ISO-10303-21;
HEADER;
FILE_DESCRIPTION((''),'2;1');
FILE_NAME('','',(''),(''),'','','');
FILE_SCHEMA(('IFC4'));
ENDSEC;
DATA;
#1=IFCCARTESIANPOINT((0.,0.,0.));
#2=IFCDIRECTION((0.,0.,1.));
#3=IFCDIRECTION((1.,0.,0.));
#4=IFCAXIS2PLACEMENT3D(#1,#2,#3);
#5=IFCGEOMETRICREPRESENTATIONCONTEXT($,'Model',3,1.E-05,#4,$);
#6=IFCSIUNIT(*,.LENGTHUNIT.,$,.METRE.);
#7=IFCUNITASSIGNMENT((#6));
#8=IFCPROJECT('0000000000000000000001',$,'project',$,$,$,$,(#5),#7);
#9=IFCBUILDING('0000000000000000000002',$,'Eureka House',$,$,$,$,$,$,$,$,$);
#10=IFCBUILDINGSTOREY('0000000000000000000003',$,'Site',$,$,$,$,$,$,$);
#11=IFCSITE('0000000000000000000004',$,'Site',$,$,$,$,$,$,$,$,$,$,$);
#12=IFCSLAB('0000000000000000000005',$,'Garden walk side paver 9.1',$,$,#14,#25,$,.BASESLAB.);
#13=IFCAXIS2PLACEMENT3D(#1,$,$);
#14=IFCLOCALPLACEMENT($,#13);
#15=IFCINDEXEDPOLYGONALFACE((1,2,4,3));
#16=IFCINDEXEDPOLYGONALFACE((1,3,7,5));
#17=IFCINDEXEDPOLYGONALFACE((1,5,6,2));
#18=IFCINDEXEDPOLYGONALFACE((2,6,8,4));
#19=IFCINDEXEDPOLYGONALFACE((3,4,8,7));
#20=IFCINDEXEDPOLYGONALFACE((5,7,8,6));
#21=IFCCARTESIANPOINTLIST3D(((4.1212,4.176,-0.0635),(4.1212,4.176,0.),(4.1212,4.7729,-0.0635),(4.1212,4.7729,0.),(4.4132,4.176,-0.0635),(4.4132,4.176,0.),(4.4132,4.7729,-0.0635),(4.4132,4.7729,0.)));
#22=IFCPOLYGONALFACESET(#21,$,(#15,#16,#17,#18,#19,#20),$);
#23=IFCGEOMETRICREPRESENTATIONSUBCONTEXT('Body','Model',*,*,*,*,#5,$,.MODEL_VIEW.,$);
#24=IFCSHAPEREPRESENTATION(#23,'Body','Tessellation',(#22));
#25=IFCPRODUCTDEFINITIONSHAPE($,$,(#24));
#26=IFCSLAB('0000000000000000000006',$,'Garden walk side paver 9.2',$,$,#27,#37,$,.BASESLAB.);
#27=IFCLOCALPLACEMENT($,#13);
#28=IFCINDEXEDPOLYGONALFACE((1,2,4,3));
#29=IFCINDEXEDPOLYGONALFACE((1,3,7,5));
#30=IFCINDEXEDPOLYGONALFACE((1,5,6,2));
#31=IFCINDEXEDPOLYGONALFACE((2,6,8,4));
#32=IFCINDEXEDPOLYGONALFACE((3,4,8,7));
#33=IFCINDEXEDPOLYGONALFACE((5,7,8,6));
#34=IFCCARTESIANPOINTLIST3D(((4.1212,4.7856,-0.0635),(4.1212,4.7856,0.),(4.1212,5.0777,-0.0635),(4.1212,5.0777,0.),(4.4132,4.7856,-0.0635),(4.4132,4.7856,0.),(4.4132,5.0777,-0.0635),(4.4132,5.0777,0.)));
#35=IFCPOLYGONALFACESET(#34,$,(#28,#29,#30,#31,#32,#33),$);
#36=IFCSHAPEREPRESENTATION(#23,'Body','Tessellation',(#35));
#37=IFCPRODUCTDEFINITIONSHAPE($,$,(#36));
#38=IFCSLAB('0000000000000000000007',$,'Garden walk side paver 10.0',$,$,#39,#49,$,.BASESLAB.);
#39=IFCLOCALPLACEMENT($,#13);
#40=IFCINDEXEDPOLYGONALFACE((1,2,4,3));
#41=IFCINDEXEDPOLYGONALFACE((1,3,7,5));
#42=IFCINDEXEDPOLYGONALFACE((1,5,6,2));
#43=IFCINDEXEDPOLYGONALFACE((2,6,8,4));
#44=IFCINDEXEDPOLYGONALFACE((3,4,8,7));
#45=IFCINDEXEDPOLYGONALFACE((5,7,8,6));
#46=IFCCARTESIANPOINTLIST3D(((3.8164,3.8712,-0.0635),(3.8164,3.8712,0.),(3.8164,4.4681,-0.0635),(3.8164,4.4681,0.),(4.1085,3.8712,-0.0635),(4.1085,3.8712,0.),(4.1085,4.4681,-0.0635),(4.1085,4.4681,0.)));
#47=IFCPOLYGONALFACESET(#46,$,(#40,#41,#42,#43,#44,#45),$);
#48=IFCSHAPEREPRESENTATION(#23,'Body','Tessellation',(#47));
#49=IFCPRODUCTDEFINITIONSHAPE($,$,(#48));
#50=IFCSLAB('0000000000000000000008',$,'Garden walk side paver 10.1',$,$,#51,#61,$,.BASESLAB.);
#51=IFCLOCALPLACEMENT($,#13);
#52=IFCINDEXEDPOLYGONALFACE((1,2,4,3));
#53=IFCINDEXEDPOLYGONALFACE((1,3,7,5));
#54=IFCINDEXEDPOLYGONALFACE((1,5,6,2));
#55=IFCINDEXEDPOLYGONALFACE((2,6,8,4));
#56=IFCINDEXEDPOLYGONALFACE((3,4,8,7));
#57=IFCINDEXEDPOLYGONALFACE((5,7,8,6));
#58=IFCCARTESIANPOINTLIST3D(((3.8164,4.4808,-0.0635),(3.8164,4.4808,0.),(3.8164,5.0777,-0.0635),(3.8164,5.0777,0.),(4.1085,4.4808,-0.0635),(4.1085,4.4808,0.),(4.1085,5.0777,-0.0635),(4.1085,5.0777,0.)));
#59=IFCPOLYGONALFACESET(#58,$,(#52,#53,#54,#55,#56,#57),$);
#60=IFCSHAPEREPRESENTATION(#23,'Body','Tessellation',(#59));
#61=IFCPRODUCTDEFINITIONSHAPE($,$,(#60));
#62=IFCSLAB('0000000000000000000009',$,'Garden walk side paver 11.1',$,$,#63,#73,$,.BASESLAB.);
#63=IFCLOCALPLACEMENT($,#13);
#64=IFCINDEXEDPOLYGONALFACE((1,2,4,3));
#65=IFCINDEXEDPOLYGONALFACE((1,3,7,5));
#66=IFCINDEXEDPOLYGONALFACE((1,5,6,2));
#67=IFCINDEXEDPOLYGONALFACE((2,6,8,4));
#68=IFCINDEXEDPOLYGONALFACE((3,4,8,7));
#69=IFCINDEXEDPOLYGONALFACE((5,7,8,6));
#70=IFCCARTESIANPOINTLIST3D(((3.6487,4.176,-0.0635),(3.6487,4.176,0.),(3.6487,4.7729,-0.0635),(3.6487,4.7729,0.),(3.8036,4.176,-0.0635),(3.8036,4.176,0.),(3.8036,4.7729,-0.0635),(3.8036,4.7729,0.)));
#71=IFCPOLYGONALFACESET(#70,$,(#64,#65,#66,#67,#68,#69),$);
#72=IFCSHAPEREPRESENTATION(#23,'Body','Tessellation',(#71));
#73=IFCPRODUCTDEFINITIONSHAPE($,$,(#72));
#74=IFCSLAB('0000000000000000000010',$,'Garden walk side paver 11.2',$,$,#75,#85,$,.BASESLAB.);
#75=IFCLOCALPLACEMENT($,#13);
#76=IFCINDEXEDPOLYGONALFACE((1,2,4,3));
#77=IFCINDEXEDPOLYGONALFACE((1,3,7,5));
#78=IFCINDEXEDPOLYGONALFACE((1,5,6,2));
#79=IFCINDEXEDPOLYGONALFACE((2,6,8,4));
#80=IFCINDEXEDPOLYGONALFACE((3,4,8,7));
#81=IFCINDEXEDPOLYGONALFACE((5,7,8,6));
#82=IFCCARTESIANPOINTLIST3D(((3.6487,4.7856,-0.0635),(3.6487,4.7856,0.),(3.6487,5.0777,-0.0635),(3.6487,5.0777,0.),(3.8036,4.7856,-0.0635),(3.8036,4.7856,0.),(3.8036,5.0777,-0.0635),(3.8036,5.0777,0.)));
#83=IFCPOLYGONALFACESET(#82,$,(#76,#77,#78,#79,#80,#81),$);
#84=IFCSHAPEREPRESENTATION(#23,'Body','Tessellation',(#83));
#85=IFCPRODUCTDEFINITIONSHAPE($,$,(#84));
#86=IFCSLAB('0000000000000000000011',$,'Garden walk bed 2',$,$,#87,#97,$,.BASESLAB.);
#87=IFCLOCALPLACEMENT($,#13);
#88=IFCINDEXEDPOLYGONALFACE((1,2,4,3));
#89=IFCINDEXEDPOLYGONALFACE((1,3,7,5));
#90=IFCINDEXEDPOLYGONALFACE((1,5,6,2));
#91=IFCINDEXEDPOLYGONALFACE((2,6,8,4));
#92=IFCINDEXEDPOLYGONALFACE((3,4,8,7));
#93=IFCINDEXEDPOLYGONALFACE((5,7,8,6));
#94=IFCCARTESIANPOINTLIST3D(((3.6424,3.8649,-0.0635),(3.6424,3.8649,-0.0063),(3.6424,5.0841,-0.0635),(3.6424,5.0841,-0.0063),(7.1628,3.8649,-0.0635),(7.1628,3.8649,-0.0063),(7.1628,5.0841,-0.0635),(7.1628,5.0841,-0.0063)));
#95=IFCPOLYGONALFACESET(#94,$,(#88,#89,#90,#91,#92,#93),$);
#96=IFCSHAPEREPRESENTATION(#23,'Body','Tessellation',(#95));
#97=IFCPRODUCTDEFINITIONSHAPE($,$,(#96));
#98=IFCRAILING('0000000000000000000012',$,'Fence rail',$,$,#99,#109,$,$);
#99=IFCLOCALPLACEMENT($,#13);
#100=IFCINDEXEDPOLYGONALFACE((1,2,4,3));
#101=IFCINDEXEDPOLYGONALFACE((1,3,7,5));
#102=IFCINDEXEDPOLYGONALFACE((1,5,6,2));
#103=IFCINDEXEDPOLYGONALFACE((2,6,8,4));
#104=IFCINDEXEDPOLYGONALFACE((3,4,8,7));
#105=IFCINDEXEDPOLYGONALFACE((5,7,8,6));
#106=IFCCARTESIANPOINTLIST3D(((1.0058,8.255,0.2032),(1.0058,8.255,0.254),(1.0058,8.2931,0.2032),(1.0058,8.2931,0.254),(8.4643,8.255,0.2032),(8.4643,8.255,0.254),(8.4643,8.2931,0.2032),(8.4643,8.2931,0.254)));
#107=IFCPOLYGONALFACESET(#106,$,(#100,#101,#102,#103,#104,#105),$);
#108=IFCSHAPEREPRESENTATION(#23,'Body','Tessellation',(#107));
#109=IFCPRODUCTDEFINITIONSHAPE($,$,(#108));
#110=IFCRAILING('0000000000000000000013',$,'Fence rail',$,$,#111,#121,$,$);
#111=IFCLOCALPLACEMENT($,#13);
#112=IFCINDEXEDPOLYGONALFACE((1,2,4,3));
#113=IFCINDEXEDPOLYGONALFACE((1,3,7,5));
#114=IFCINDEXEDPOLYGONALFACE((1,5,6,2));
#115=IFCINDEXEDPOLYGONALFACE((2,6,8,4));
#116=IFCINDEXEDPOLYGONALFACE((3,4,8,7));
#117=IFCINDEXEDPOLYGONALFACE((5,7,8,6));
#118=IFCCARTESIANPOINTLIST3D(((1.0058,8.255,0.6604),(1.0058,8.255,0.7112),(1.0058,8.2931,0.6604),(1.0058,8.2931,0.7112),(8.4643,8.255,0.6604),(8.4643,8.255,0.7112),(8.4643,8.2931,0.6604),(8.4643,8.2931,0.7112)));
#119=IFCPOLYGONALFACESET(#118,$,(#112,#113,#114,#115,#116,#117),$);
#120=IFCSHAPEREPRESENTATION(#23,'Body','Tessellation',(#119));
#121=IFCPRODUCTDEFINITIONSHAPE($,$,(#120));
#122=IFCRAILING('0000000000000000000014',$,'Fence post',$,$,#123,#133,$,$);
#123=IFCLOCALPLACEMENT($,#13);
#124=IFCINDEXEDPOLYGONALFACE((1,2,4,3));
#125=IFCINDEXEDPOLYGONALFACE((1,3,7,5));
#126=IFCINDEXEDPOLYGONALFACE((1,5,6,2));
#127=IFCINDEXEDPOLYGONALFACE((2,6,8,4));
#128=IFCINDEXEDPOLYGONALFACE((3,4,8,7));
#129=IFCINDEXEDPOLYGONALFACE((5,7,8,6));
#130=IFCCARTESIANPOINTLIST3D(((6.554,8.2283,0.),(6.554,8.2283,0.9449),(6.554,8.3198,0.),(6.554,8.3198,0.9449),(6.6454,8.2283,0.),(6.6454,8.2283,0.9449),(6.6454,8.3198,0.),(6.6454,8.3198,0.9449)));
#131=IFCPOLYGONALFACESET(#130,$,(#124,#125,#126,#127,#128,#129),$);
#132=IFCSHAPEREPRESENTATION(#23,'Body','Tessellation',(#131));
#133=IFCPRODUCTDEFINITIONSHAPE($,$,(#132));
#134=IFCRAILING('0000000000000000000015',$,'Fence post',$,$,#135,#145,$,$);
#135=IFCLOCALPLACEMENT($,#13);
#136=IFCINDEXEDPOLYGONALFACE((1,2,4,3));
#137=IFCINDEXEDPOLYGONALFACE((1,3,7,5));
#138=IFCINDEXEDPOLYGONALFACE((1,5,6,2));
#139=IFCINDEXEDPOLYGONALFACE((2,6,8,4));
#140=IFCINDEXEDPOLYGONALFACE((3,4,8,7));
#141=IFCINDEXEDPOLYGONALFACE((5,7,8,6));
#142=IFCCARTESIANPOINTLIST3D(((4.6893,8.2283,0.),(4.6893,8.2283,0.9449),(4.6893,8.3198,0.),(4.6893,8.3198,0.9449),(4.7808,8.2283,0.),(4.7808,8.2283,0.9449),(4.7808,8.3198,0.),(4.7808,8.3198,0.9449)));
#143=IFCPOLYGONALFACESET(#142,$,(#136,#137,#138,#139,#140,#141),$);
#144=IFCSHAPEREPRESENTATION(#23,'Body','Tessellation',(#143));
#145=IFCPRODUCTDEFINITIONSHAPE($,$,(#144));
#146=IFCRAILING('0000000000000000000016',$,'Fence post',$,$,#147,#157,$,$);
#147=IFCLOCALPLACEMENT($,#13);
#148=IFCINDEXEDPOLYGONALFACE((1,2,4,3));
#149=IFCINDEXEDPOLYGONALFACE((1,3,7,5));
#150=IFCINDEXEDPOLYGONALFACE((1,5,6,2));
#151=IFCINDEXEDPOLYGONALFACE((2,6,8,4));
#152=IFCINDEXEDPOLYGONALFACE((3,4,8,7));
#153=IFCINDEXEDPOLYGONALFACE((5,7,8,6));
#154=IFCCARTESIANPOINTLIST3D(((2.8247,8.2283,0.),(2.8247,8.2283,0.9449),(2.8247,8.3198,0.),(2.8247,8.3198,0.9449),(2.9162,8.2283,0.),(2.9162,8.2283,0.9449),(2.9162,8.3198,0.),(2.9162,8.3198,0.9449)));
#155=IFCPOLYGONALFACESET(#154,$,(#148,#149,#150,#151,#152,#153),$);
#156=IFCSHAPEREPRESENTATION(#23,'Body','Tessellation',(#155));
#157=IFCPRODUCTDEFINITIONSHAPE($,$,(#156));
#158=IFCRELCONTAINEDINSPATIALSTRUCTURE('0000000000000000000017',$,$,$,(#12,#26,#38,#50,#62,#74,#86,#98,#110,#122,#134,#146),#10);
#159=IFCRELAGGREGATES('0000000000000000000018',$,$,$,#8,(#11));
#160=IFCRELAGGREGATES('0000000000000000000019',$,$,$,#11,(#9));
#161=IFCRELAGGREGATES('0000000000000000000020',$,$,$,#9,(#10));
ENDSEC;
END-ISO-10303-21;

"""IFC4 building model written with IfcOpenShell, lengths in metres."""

from ifc_helpers import new_model, si_unit, frame, origin, origin_with_axes, origin_2d, place, context, subcontext, project, spatial, rectangle, extrude, element, save


model = new_model("IFC4")

# Units and contexts
model_context = context("Model", 3, precision=1e-05, world=origin_with_axes())
body_context = subcontext(model_context, "Body", "Model", "MODEL_VIEW")
ifc_project = project(units=[si_unit("LENGTHUNIT", "METRE")], contexts=[model_context])

# Site, building, storey
site = spatial("IfcSite", under=ifc_project, Name="Site")
building = spatial("IfcBuilding", under=site, Name="Eureka House")
storey = spatial("IfcBuildingStorey", under=building, Name="Site")

# Slabs
slab_1_placement = place(None, frame((4.2672, 4.4745, -0.0635), z_axis=(0.0, 0.0, 1.0), x_axis=(1.0, 0.0, 0.0)))
element("IfcSlab", 1, at=slab_1_placement, inside=storey, Name="Garden walk side paver 9.1", PredefinedType="BASESLAB", context=body_context, shape_type="SweptSolid", body=[
    extrude(rectangle(XDim=0.2921, YDim=0.5969, at=origin_2d()), origin(), (0.0, 0.0, 1.0), 0.0635),
])
slab_2_placement = place(None, frame((4.2672, 4.9317, -0.0635), z_axis=(0.0, 0.0, 1.0), x_axis=(1.0, 0.0, 0.0)))
element("IfcSlab", 2, at=slab_2_placement, inside=storey, Name="Garden walk side paver 9.2", PredefinedType="BASESLAB", context=body_context, shape_type="SweptSolid", body=[
    extrude(rectangle(XDim=0.2921, YDim=0.2921, at=origin_2d()), origin(), (0.0, 0.0, 1.0), 0.0635),
])
slab_3_placement = place(None, frame((3.9624, 4.1697, -0.0635), z_axis=(0.0, 0.0, 1.0), x_axis=(1.0, 0.0, 0.0)))
element("IfcSlab", 3, at=slab_3_placement, inside=storey, Name="Garden walk side paver 10.0", PredefinedType="BASESLAB", context=body_context, shape_type="SweptSolid", body=[
    extrude(rectangle(XDim=0.2921, YDim=0.5969, at=origin_2d()), origin(), (0.0, 0.0, 1.0), 0.0635),
])
slab_4_placement = place(None, frame((3.9624, 4.7793, -0.0635), z_axis=(0.0, 0.0, 1.0), x_axis=(1.0, 0.0, 0.0)))
element("IfcSlab", 4, at=slab_4_placement, inside=storey, Name="Garden walk side paver 10.1", PredefinedType="BASESLAB", context=body_context, shape_type="SweptSolid", body=[
    extrude(rectangle(XDim=0.2921, YDim=0.5969, at=origin_2d()), origin(), (0.0, 0.0, 1.0), 0.0635),
])
slab_5_placement = place(None, frame((3.7262, 4.4745, -0.0635), z_axis=(0.0, 0.0, 1.0), x_axis=(1.0, 0.0, 0.0)))
element("IfcSlab", 5, at=slab_5_placement, inside=storey, Name="Garden walk side paver 11.1", PredefinedType="BASESLAB", context=body_context, shape_type="SweptSolid", body=[
    extrude(rectangle(XDim=0.1549, YDim=0.5969, at=origin_2d()), origin(), (0.0, 0.0, 1.0), 0.0635),
])
slab_6_placement = place(None, frame((3.7262, 4.9317, -0.0635), z_axis=(0.0, 0.0, 1.0), x_axis=(1.0, 0.0, 0.0)))
element("IfcSlab", 6, at=slab_6_placement, inside=storey, Name="Garden walk side paver 11.2", PredefinedType="BASESLAB", context=body_context, shape_type="SweptSolid", body=[
    extrude(rectangle(XDim=0.1549, YDim=0.2921, at=origin_2d()), origin(), (0.0, 0.0, 1.0), 0.0635),
])
slab_7_placement = place(None, frame((5.4026, 4.4745, -0.0635), z_axis=(0.0, 0.0, 1.0), x_axis=(1.0, 0.0, 0.0)))
element("IfcSlab", 7, at=slab_7_placement, inside=storey, Name="Garden walk bed 2", PredefinedType="BASESLAB", context=body_context, shape_type="SweptSolid", body=[
    extrude(rectangle(XDim=3.5204, YDim=1.2192, at=origin_2d()), origin(), (0.0, 0.0, 1.0), 0.0572),
])

# Railings
for number, where, z_axis, x_axis, name in (
    (8, (4.7351, 8.274, 0.2032), (0.0, 0.0, 1.0), (1.0, 0.0, 0.0), "Fence rail"),
    (9, (4.7351, 8.274, 0.6604), (0.0, 0.0, 1.0), (1.0, 0.0, 0.0), "Fence rail"),
):
    element("IfcRailing", number, at=place(None, frame(where, z_axis=z_axis, x_axis=x_axis)), inside=storey, Name=name, context=body_context, shape_type="SweptSolid", body=[
        extrude(rectangle(XDim=7.4585, YDim=0.0381, at=origin_2d()), origin(), (0.0, 0.0, 1.0), 0.0508),
    ])
for number, where, z_axis, x_axis, name in (
    (10, (6.5997, 8.274, 0.0), (0.0, 0.0, 1.0), (1.0, 0.0, 0.0), "Fence post"),
    (11, (4.7351, 8.274, 0.0), (0.0, 0.0, 1.0), (1.0, 0.0, 0.0), "Fence post"),
    (12, (2.8705, 8.274, 0.0), (0.0, 0.0, 1.0), (1.0, 0.0, 0.0), "Fence post"),
):
    element("IfcRailing", number, at=place(None, frame(where, z_axis=z_axis, x_axis=x_axis)), inside=storey, Name=name, context=body_context, shape_type="SweptSolid", body=[
        extrude(rectangle(XDim=0.0914, YDim=0.0914, at=origin_2d()), origin(), (0.0, 0.0, 1.0), 0.9449),
    ])

save(model, "model.ifc")
